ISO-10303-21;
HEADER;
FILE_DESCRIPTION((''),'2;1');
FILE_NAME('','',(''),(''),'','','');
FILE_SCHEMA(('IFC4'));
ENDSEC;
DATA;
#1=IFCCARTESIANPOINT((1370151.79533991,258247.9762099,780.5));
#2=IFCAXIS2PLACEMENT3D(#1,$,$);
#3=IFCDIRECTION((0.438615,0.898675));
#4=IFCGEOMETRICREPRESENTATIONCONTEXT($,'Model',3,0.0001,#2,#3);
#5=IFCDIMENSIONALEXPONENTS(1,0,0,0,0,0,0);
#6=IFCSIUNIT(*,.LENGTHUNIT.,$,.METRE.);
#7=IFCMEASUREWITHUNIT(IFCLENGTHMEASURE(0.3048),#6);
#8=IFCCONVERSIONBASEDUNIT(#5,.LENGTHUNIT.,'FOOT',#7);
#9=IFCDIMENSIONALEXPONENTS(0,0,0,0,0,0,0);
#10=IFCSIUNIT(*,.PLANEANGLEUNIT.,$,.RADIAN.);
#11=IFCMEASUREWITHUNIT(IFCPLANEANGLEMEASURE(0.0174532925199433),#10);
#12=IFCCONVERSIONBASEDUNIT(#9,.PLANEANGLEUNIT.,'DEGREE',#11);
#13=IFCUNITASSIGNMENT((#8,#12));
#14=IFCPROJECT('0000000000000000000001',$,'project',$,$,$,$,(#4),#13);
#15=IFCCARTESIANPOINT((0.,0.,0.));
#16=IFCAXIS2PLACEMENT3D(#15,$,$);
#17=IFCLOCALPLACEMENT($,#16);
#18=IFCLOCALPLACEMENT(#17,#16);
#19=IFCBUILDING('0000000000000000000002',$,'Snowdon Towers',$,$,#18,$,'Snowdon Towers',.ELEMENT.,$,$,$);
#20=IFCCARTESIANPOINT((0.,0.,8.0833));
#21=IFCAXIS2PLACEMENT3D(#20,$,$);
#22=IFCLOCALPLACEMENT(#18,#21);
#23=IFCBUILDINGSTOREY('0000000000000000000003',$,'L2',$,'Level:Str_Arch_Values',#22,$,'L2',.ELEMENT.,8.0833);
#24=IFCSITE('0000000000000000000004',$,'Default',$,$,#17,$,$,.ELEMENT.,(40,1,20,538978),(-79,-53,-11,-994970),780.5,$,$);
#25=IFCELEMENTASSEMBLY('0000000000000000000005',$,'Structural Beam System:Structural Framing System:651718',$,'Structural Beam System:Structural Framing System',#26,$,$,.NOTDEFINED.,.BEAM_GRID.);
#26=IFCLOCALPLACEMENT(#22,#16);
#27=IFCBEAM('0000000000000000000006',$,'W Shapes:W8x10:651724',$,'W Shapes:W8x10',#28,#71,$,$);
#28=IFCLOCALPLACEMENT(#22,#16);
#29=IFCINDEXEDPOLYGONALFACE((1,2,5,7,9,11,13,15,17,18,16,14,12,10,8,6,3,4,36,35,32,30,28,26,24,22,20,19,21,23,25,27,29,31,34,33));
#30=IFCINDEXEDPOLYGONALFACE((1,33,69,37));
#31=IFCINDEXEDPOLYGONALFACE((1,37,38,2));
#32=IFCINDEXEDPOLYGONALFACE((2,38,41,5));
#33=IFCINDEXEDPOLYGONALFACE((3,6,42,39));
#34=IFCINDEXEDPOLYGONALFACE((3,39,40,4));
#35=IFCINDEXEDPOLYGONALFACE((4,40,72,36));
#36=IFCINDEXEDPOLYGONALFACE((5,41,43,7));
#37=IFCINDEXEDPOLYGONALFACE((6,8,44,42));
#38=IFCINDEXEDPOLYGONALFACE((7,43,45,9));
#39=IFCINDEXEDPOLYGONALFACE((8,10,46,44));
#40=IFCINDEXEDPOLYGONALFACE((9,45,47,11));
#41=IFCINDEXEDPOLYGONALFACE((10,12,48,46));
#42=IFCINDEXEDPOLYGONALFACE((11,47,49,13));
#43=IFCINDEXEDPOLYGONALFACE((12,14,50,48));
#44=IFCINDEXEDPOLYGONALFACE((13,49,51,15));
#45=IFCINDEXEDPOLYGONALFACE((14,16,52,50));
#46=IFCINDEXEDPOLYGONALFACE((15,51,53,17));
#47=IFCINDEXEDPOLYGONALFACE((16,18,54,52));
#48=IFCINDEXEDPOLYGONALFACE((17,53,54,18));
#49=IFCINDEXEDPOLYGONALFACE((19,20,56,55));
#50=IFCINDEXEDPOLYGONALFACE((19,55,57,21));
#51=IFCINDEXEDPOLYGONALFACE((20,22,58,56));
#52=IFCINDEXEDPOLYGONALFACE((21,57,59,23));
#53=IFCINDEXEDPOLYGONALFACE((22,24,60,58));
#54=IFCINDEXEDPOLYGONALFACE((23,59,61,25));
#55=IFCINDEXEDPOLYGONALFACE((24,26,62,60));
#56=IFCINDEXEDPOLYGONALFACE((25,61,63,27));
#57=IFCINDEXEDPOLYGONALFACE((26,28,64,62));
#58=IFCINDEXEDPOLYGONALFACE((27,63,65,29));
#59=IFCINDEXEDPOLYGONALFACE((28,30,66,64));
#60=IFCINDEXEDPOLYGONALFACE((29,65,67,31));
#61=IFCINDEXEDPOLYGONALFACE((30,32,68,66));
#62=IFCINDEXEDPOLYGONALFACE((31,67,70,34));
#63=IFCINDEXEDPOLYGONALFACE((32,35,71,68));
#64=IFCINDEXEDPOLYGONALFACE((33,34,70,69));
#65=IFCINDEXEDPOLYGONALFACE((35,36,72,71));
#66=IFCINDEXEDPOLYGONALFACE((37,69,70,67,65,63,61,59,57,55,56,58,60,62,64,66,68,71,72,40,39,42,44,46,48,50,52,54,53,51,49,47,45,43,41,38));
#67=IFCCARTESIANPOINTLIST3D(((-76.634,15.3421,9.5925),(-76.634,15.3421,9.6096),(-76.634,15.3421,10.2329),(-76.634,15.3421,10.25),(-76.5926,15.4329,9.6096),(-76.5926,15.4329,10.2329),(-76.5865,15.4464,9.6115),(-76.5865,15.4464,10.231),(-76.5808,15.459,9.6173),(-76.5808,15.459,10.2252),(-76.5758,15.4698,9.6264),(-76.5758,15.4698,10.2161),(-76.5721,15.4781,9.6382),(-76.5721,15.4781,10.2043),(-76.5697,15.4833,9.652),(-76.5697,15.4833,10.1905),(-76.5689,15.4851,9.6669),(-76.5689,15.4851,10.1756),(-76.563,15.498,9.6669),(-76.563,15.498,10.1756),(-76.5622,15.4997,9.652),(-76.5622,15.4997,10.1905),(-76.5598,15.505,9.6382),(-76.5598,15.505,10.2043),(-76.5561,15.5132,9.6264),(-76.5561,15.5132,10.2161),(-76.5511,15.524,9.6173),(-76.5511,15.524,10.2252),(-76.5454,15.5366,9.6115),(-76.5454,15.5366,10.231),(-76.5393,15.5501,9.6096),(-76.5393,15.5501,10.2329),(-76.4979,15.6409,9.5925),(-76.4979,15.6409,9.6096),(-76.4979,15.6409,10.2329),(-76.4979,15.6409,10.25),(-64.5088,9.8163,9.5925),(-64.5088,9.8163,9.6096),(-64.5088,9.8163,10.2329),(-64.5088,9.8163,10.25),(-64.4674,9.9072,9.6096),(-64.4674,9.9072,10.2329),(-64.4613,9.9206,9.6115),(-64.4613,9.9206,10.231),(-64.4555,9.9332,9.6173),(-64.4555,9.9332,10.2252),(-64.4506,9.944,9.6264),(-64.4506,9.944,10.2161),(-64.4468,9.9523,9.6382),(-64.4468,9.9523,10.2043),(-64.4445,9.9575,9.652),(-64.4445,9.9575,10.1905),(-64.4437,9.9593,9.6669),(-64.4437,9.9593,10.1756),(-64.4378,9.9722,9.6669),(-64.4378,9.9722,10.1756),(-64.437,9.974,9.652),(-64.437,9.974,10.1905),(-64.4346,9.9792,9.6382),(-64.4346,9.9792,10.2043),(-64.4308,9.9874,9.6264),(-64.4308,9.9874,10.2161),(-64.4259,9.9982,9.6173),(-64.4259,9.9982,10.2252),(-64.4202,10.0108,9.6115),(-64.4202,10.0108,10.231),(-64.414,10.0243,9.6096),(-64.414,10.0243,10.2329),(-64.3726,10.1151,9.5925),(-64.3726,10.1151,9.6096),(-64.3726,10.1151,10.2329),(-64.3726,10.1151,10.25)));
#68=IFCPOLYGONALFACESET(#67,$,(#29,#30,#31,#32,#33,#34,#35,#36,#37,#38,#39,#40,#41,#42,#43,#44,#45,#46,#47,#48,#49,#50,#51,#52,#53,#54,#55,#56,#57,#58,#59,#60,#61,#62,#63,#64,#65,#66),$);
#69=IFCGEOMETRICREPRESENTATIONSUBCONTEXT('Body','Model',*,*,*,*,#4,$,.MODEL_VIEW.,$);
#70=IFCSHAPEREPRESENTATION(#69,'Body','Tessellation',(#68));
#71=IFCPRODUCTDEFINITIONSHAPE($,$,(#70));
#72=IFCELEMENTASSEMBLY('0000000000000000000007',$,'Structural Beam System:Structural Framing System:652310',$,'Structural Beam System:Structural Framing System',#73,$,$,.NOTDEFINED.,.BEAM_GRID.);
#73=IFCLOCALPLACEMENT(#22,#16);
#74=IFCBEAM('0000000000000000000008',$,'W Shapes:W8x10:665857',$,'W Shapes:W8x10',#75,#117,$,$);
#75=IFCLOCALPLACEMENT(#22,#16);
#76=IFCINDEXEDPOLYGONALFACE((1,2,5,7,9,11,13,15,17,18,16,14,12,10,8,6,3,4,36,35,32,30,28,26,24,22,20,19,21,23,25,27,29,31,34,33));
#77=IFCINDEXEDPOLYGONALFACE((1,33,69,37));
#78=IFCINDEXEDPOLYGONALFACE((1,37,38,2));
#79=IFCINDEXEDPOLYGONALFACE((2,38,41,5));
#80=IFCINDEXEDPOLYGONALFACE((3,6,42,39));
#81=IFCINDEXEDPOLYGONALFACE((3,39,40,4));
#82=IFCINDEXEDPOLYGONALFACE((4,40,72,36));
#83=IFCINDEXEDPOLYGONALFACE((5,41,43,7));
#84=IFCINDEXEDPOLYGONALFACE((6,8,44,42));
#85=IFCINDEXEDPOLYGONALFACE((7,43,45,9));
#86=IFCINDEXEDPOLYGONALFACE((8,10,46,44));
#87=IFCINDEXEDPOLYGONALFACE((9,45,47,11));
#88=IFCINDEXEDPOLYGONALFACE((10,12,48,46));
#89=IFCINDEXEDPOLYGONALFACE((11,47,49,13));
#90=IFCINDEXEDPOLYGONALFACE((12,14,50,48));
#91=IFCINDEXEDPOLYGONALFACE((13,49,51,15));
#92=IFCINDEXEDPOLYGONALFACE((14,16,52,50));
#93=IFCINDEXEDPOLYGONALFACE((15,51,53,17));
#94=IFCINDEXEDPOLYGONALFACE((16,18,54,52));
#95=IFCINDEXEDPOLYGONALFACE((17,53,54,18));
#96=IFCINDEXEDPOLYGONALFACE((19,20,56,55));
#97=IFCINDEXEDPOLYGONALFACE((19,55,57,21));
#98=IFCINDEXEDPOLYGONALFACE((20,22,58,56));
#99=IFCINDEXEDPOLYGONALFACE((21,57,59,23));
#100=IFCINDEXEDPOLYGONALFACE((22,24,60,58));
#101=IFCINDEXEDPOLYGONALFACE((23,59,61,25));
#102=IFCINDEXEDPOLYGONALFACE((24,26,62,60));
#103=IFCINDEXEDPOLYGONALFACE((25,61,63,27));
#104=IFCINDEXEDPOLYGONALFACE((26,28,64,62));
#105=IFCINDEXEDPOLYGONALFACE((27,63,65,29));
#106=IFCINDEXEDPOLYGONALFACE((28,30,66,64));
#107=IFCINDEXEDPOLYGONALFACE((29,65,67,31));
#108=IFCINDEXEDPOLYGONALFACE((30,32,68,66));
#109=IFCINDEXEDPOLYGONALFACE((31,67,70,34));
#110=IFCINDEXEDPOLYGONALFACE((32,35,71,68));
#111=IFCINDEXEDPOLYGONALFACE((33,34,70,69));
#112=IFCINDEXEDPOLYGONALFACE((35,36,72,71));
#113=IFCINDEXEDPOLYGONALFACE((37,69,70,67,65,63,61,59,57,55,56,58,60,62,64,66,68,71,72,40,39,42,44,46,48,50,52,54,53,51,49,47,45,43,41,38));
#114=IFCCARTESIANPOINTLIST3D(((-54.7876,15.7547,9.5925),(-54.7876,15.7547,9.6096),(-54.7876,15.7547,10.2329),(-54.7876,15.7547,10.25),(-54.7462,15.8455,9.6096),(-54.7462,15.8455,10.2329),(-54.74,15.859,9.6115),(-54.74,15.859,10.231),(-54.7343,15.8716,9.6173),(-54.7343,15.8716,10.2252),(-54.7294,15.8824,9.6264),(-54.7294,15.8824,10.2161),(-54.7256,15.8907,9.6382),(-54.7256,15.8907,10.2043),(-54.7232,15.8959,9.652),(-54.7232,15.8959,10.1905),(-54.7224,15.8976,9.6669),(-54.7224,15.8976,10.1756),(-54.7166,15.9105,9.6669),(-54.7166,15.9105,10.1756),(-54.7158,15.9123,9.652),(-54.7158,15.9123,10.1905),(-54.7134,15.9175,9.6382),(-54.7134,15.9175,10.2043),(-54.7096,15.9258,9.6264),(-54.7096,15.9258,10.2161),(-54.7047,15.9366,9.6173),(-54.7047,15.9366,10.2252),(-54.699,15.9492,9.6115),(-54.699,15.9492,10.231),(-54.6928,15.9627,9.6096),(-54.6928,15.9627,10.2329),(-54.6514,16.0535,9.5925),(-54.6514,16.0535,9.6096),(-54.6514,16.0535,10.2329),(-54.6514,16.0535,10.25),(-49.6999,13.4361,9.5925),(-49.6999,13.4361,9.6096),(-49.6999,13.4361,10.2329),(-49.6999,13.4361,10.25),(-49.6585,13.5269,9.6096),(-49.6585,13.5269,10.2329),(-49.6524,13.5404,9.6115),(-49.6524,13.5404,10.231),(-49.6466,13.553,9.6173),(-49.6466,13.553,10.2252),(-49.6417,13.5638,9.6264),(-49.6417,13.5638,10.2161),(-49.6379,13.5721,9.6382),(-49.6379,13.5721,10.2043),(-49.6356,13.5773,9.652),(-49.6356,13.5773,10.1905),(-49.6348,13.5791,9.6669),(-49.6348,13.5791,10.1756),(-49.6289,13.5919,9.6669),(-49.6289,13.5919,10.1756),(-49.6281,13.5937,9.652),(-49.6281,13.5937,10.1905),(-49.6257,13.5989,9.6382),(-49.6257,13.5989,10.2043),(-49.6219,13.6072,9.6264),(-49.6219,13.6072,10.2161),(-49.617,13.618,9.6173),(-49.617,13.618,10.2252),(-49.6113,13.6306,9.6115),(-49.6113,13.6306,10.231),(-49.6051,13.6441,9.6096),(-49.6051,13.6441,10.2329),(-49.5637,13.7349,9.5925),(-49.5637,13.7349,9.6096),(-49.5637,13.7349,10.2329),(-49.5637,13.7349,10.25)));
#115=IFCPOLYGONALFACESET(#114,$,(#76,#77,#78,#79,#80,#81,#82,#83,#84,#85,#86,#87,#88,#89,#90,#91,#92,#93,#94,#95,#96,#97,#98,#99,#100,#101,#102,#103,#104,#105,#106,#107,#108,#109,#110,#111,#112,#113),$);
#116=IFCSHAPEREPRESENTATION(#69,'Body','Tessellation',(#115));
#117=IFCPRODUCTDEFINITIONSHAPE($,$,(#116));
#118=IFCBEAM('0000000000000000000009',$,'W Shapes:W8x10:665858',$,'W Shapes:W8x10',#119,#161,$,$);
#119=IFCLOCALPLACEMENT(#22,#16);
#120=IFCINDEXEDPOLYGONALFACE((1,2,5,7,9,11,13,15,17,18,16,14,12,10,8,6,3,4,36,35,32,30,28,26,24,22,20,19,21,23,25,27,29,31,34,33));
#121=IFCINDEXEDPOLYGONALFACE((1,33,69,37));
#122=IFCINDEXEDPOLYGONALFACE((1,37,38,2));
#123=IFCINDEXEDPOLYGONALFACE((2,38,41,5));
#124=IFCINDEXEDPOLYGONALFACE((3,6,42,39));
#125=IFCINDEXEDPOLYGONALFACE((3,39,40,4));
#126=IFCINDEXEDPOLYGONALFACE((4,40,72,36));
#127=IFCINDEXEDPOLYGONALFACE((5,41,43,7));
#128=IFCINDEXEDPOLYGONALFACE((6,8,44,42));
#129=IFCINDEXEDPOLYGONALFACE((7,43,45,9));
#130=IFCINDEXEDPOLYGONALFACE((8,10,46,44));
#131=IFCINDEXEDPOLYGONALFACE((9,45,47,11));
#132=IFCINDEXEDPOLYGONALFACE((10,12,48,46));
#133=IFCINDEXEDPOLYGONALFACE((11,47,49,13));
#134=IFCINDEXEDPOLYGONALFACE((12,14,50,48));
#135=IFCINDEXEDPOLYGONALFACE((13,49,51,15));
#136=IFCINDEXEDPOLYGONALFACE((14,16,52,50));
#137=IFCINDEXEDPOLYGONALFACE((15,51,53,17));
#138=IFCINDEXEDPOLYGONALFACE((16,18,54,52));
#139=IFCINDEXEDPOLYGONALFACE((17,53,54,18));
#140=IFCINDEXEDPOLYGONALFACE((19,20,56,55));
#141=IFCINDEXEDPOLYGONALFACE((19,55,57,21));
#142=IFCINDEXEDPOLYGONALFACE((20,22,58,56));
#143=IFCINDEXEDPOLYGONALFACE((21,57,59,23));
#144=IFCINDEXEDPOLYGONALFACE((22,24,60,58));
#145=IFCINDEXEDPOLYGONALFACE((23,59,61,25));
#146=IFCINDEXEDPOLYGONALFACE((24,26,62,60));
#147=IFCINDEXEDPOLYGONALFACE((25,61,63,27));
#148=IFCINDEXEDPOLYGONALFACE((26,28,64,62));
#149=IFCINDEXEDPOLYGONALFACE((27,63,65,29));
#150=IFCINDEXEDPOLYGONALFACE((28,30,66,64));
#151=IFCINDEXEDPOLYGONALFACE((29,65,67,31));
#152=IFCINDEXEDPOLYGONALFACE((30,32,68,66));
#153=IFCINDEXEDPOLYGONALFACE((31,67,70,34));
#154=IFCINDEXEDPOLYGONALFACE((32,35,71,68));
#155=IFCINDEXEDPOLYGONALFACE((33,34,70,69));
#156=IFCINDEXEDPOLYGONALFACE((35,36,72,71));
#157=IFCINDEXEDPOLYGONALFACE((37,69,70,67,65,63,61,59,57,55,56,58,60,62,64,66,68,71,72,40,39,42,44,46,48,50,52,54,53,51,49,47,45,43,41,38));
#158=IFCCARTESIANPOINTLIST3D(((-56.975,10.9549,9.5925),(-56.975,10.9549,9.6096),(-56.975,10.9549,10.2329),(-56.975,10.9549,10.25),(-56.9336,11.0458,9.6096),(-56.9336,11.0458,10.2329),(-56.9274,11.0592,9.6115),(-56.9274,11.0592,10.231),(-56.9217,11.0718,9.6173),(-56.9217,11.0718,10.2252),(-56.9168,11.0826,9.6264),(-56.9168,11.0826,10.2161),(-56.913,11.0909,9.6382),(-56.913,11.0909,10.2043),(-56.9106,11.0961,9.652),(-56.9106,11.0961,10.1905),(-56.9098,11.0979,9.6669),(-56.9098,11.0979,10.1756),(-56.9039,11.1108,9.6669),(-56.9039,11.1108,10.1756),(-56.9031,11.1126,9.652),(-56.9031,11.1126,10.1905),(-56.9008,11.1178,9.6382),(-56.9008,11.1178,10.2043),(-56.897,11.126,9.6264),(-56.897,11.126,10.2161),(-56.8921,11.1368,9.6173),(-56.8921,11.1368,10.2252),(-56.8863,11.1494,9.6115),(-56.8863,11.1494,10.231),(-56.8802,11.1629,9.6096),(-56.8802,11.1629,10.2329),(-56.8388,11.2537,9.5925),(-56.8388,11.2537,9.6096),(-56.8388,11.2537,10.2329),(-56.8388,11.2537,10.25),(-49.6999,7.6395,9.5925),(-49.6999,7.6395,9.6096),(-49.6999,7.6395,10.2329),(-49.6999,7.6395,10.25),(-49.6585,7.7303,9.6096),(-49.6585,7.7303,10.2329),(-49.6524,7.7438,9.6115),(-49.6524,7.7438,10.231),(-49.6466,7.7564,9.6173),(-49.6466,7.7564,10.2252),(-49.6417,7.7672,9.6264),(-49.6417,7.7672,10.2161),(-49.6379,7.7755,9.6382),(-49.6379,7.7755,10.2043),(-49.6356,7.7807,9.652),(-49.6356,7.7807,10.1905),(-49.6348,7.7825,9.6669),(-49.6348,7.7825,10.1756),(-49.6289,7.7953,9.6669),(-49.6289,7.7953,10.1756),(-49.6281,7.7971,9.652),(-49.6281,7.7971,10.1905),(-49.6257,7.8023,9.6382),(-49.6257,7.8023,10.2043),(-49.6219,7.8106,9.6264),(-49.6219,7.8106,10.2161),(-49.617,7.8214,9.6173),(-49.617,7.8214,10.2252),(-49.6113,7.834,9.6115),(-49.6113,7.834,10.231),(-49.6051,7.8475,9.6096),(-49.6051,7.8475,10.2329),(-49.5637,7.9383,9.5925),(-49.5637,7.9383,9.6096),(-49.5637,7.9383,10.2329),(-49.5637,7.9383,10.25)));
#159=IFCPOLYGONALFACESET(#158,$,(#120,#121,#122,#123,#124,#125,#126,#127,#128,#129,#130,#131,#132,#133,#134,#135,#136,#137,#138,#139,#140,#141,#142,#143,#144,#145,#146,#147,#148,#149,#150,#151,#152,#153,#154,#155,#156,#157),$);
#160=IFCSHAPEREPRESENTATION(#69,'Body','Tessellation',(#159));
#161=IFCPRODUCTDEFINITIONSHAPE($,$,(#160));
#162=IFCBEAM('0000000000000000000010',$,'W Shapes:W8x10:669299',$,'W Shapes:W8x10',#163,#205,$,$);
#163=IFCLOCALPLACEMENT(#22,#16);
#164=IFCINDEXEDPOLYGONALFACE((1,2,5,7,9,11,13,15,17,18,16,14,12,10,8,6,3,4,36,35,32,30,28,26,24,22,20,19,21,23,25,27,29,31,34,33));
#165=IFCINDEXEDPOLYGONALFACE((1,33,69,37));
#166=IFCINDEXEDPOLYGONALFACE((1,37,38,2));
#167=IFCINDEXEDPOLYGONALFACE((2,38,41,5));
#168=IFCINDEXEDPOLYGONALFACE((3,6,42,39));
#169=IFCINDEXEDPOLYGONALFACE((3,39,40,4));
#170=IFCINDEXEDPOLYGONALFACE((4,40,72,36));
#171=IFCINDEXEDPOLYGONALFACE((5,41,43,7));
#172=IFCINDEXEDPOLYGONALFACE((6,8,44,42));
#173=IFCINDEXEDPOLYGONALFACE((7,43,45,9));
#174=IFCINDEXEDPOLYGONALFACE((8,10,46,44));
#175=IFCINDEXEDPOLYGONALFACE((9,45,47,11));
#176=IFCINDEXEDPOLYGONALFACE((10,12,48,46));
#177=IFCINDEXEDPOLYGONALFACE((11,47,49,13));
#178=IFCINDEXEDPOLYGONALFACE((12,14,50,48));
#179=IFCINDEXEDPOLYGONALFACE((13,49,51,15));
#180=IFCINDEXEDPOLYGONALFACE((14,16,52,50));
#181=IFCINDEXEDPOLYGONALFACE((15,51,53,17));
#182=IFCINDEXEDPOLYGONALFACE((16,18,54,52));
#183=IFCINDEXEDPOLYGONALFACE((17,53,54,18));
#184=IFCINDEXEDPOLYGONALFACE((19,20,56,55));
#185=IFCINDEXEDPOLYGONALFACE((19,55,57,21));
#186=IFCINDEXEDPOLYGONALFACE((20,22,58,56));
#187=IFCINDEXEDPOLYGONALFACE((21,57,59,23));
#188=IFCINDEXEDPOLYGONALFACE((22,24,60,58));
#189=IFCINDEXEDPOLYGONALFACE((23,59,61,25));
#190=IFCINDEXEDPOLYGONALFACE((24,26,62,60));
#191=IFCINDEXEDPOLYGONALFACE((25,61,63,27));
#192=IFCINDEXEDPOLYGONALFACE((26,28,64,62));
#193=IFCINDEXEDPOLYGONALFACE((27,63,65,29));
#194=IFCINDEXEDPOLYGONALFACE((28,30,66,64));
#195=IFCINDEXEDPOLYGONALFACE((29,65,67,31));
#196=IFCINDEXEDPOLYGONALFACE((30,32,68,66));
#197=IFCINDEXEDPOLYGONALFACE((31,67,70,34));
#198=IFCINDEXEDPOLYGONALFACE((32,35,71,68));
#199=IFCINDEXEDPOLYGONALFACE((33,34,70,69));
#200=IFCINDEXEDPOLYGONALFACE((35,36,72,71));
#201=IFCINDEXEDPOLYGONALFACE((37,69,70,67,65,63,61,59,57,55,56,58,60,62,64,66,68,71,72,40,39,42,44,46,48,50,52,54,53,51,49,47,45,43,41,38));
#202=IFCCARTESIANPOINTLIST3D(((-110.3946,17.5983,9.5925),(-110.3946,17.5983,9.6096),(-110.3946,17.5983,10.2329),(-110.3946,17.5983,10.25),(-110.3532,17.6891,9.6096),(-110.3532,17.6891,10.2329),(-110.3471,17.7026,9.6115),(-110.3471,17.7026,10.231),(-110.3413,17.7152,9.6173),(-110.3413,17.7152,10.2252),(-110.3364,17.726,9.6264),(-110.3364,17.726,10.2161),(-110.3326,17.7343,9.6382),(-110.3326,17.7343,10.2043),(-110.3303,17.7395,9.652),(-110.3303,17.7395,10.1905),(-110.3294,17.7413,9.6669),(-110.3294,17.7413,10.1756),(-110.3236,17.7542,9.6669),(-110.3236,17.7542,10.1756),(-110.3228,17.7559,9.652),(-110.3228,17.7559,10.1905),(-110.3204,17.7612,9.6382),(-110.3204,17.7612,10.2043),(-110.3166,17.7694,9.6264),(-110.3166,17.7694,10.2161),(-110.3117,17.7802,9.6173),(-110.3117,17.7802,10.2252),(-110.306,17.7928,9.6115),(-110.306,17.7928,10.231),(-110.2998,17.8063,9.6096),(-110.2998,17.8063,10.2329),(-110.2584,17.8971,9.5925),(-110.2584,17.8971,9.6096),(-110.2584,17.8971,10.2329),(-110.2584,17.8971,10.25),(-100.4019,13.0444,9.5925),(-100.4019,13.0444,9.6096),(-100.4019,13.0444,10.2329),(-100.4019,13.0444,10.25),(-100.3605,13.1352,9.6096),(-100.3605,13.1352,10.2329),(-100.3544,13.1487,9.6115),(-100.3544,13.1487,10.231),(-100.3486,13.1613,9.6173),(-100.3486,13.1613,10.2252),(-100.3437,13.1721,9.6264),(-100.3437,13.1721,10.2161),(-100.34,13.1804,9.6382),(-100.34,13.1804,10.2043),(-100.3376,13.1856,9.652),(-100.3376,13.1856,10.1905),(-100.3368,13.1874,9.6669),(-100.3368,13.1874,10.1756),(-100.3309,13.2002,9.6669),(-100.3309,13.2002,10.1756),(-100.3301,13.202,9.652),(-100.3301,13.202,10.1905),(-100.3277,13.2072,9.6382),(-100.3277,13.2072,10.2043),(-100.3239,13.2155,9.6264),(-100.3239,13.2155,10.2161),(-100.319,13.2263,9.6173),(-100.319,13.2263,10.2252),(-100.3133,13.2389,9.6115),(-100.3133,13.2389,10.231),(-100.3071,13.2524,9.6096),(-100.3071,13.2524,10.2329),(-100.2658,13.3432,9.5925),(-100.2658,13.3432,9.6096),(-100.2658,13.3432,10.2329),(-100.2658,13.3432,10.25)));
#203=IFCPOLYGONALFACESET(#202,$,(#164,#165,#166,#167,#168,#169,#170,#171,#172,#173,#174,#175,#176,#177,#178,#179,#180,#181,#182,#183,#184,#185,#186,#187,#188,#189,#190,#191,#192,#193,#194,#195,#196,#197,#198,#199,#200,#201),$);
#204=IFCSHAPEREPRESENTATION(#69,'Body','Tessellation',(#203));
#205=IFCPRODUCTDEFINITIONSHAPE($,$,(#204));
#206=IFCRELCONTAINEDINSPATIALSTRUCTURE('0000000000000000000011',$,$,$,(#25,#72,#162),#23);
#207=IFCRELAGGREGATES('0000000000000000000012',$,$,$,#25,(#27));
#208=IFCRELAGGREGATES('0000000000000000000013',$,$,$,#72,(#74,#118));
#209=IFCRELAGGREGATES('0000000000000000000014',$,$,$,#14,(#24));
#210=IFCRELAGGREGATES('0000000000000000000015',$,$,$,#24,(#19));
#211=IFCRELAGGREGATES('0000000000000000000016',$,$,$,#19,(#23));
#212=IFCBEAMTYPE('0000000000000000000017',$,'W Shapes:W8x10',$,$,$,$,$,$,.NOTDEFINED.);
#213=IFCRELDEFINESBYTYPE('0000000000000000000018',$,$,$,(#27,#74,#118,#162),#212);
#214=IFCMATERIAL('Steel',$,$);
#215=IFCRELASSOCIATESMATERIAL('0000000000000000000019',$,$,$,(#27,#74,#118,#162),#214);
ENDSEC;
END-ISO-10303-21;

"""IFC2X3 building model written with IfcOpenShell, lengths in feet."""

from ifc_helpers import new_model, entity, si_unit, converted_unit, direction, frame, frame_2d, origin, place, context, subcontext, project, spatial, i_section, extrude, material, type_object, element, aggregate, save


model = new_model("IFC2X3")

# Units and contexts
model_context = context("Model", 3, precision=0.0001, world=frame((1370151.79533991, 258247.9762099, 780.5)), true_north=direction((0.438615, 0.898675)))
body_context = subcontext(model_context, "Body", "Model", "MODEL_VIEW")
ifc_project = project(units=[converted_unit("LENGTHUNIT", "FOOT", entity("IfcLengthMeasure", 0.3048), si_unit("LENGTHUNIT", "METRE"), dimensions=[1, 0, 0, 0, 0, 0, 0]), converted_unit("PLANEANGLEUNIT", "DEGREE", entity("IfcPlaneAngleMeasure", 0.0174532925199433), si_unit("PLANEANGLEUNIT", "RADIAN"), dimensions=[0, 0, 0, 0, 0, 0, 0])], contexts=[model_context])

# Site, building, storey
site_placement = place(None, origin())
site = spatial("IfcSite", under=ifc_project, at=site_placement, Name="Default", CompositionType="ELEMENT", RefLatitude=(40, 1, 20, 538978), RefLongitude=(-79, -53, -11, -994970), RefElevation=780.5)
building_placement = place(site_placement, origin())
building = spatial("IfcBuilding", under=site, at=building_placement, Name="Snowdon Towers", LongName="Snowdon Towers", CompositionType="ELEMENT")
storey_placement = place(building_placement, frame((0.0, 0.0, 8.0833)))
storey = spatial("IfcBuildingStorey", under=building, at=storey_placement, Name="L2", ObjectType="Level:Str_Arch_Values", LongName="L2", CompositionType="ELEMENT", Elevation=8.0833)

# Shared definitions
ifc_material = material(Name="Steel")
beam_type_1 = type_object("IfcBeamType", Name="W Shapes:W8x10", PredefinedType="NOTDEFINED")

# Element assemblies, beams
assembly_1_placement = place(storey_placement, origin())
assembly_1 = element("IfcElementAssembly", 1, at=assembly_1_placement, inside=storey, Name="Structural Beam System:Structural Framing System:651718", ObjectType="Structural Beam System:Structural Framing System", AssemblyPlace="NOTDEFINED", PredefinedType="BEAM_GRID")
beam_1_placement = place(assembly_1_placement, frame((-76.9868, 15.6833, 10.25), z_axis=(0.0, 0.0, 1.0), x_axis=(0.909961, -0.414693, 0.0)))
beam_1 = element("IfcBeam", 2, at=beam_1_placement, type_object=beam_type_1, material=ifc_material, Name="W Shapes:W8x10:651724", ObjectType="W Shapes:W8x10", context=body_context, shape_type="SweptSolid", body=[
    extrude(i_section(OverallWidth=0.3283, OverallDepth=0.6575, WebThickness=0.0142, FlangeThickness=0.0171, FilletRadius=0.0573, at=frame_2d((0.0, 0.0), x_axis=(0.0, 1.0))), frame((0.4625, 0.0, -0.3288), z_axis=(1.0, 0.0, 0.0), x_axis=(0.0, 0.0, -1.0)), (0.0, 0.0, 1.0), 13.325),
])
aggregate(assembly_1, [beam_1])
assembly_2_placement = place(storey_placement, origin())
assembly_2 = element("IfcElementAssembly", 3, at=assembly_2_placement, inside=storey, Name="Structural Beam System:Structural Framing System:652310", ObjectType="Structural Beam System:Structural Framing System", AssemblyPlace="NOTDEFINED", PredefinedType="BEAM_GRID")
beam_2_placement = place(assembly_2_placement, frame((-55.1404, 16.0959, 10.25), z_axis=(0.0, 0.0, 1.0), x_axis=(0.909961, -0.414693, 0.0)))
beam_2 = element("IfcBeam", 4, at=beam_2_placement, type_object=beam_type_1, material=ifc_material, Name="W Shapes:W8x10:665857", ObjectType="W Shapes:W8x10", context=body_context, shape_type="SweptSolid", body=[
    extrude(i_section(OverallWidth=0.3283, OverallDepth=0.6575, WebThickness=0.0142, FlangeThickness=0.0171, FilletRadius=0.0573, at=frame_2d((0.0, 0.0), x_axis=(0.0, 1.0))), frame((0.4625, 0.0, -0.3288), z_axis=(1.0, 0.0, 0.0), x_axis=(0.0, 0.0, -1.0)), (0.0, 0.0, 1.0), 5.5911),
])
beam_3_placement = place(assembly_2_placement, frame((-57.3277, 11.2961, 10.25), z_axis=(0.0, 0.0, 1.0), x_axis=(0.909961, -0.414693, 0.0)))
beam_3 = element("IfcBeam", 5, at=beam_3_placement, type_object=beam_type_1, material=ifc_material, Name="W Shapes:W8x10:665858", ObjectType="W Shapes:W8x10", context=body_context, shape_type="SweptSolid", body=[
    extrude(i_section(OverallWidth=0.3283, OverallDepth=0.6575, WebThickness=0.0142, FlangeThickness=0.0171, FilletRadius=0.0573, at=frame_2d((0.0, 0.0), x_axis=(0.0, 1.0))), frame((0.4625, 0.0, -0.3288), z_axis=(1.0, 0.0, 0.0), x_axis=(0.0, 0.0, -1.0)), (0.0, 0.0, 1.0), 7.9949),
])
aggregate(assembly_2, [beam_2, beam_3])

# Beam
beam_4_placement = place(storey_placement, frame((-110.7083, 17.9217, 10.25), z_axis=(0.0, 0.0, 1.0), x_axis=(0.909961, -0.414693, 0.0)))
element("IfcBeam", 6, at=beam_4_placement, inside=storey, type_object=beam_type_1, material=ifc_material, Name="W Shapes:W8x10:669299", ObjectType="W Shapes:W8x10", context=body_context, shape_type="SweptSolid", body=[
    extrude(i_section(OverallWidth=0.3283, OverallDepth=0.6575, WebThickness=0.0142, FlangeThickness=0.0171, FilletRadius=0.0573, at=frame_2d((0.0, 0.0), x_axis=(0.0, 1.0))), frame((0.4196, 0.0, -0.3288), z_axis=(1.0, 0.0, 0.0), x_axis=(0.0, 0.0, -1.0)), (0.0, 0.0, 1.0), 10.9814),
])

save(model, "model.ifc")
